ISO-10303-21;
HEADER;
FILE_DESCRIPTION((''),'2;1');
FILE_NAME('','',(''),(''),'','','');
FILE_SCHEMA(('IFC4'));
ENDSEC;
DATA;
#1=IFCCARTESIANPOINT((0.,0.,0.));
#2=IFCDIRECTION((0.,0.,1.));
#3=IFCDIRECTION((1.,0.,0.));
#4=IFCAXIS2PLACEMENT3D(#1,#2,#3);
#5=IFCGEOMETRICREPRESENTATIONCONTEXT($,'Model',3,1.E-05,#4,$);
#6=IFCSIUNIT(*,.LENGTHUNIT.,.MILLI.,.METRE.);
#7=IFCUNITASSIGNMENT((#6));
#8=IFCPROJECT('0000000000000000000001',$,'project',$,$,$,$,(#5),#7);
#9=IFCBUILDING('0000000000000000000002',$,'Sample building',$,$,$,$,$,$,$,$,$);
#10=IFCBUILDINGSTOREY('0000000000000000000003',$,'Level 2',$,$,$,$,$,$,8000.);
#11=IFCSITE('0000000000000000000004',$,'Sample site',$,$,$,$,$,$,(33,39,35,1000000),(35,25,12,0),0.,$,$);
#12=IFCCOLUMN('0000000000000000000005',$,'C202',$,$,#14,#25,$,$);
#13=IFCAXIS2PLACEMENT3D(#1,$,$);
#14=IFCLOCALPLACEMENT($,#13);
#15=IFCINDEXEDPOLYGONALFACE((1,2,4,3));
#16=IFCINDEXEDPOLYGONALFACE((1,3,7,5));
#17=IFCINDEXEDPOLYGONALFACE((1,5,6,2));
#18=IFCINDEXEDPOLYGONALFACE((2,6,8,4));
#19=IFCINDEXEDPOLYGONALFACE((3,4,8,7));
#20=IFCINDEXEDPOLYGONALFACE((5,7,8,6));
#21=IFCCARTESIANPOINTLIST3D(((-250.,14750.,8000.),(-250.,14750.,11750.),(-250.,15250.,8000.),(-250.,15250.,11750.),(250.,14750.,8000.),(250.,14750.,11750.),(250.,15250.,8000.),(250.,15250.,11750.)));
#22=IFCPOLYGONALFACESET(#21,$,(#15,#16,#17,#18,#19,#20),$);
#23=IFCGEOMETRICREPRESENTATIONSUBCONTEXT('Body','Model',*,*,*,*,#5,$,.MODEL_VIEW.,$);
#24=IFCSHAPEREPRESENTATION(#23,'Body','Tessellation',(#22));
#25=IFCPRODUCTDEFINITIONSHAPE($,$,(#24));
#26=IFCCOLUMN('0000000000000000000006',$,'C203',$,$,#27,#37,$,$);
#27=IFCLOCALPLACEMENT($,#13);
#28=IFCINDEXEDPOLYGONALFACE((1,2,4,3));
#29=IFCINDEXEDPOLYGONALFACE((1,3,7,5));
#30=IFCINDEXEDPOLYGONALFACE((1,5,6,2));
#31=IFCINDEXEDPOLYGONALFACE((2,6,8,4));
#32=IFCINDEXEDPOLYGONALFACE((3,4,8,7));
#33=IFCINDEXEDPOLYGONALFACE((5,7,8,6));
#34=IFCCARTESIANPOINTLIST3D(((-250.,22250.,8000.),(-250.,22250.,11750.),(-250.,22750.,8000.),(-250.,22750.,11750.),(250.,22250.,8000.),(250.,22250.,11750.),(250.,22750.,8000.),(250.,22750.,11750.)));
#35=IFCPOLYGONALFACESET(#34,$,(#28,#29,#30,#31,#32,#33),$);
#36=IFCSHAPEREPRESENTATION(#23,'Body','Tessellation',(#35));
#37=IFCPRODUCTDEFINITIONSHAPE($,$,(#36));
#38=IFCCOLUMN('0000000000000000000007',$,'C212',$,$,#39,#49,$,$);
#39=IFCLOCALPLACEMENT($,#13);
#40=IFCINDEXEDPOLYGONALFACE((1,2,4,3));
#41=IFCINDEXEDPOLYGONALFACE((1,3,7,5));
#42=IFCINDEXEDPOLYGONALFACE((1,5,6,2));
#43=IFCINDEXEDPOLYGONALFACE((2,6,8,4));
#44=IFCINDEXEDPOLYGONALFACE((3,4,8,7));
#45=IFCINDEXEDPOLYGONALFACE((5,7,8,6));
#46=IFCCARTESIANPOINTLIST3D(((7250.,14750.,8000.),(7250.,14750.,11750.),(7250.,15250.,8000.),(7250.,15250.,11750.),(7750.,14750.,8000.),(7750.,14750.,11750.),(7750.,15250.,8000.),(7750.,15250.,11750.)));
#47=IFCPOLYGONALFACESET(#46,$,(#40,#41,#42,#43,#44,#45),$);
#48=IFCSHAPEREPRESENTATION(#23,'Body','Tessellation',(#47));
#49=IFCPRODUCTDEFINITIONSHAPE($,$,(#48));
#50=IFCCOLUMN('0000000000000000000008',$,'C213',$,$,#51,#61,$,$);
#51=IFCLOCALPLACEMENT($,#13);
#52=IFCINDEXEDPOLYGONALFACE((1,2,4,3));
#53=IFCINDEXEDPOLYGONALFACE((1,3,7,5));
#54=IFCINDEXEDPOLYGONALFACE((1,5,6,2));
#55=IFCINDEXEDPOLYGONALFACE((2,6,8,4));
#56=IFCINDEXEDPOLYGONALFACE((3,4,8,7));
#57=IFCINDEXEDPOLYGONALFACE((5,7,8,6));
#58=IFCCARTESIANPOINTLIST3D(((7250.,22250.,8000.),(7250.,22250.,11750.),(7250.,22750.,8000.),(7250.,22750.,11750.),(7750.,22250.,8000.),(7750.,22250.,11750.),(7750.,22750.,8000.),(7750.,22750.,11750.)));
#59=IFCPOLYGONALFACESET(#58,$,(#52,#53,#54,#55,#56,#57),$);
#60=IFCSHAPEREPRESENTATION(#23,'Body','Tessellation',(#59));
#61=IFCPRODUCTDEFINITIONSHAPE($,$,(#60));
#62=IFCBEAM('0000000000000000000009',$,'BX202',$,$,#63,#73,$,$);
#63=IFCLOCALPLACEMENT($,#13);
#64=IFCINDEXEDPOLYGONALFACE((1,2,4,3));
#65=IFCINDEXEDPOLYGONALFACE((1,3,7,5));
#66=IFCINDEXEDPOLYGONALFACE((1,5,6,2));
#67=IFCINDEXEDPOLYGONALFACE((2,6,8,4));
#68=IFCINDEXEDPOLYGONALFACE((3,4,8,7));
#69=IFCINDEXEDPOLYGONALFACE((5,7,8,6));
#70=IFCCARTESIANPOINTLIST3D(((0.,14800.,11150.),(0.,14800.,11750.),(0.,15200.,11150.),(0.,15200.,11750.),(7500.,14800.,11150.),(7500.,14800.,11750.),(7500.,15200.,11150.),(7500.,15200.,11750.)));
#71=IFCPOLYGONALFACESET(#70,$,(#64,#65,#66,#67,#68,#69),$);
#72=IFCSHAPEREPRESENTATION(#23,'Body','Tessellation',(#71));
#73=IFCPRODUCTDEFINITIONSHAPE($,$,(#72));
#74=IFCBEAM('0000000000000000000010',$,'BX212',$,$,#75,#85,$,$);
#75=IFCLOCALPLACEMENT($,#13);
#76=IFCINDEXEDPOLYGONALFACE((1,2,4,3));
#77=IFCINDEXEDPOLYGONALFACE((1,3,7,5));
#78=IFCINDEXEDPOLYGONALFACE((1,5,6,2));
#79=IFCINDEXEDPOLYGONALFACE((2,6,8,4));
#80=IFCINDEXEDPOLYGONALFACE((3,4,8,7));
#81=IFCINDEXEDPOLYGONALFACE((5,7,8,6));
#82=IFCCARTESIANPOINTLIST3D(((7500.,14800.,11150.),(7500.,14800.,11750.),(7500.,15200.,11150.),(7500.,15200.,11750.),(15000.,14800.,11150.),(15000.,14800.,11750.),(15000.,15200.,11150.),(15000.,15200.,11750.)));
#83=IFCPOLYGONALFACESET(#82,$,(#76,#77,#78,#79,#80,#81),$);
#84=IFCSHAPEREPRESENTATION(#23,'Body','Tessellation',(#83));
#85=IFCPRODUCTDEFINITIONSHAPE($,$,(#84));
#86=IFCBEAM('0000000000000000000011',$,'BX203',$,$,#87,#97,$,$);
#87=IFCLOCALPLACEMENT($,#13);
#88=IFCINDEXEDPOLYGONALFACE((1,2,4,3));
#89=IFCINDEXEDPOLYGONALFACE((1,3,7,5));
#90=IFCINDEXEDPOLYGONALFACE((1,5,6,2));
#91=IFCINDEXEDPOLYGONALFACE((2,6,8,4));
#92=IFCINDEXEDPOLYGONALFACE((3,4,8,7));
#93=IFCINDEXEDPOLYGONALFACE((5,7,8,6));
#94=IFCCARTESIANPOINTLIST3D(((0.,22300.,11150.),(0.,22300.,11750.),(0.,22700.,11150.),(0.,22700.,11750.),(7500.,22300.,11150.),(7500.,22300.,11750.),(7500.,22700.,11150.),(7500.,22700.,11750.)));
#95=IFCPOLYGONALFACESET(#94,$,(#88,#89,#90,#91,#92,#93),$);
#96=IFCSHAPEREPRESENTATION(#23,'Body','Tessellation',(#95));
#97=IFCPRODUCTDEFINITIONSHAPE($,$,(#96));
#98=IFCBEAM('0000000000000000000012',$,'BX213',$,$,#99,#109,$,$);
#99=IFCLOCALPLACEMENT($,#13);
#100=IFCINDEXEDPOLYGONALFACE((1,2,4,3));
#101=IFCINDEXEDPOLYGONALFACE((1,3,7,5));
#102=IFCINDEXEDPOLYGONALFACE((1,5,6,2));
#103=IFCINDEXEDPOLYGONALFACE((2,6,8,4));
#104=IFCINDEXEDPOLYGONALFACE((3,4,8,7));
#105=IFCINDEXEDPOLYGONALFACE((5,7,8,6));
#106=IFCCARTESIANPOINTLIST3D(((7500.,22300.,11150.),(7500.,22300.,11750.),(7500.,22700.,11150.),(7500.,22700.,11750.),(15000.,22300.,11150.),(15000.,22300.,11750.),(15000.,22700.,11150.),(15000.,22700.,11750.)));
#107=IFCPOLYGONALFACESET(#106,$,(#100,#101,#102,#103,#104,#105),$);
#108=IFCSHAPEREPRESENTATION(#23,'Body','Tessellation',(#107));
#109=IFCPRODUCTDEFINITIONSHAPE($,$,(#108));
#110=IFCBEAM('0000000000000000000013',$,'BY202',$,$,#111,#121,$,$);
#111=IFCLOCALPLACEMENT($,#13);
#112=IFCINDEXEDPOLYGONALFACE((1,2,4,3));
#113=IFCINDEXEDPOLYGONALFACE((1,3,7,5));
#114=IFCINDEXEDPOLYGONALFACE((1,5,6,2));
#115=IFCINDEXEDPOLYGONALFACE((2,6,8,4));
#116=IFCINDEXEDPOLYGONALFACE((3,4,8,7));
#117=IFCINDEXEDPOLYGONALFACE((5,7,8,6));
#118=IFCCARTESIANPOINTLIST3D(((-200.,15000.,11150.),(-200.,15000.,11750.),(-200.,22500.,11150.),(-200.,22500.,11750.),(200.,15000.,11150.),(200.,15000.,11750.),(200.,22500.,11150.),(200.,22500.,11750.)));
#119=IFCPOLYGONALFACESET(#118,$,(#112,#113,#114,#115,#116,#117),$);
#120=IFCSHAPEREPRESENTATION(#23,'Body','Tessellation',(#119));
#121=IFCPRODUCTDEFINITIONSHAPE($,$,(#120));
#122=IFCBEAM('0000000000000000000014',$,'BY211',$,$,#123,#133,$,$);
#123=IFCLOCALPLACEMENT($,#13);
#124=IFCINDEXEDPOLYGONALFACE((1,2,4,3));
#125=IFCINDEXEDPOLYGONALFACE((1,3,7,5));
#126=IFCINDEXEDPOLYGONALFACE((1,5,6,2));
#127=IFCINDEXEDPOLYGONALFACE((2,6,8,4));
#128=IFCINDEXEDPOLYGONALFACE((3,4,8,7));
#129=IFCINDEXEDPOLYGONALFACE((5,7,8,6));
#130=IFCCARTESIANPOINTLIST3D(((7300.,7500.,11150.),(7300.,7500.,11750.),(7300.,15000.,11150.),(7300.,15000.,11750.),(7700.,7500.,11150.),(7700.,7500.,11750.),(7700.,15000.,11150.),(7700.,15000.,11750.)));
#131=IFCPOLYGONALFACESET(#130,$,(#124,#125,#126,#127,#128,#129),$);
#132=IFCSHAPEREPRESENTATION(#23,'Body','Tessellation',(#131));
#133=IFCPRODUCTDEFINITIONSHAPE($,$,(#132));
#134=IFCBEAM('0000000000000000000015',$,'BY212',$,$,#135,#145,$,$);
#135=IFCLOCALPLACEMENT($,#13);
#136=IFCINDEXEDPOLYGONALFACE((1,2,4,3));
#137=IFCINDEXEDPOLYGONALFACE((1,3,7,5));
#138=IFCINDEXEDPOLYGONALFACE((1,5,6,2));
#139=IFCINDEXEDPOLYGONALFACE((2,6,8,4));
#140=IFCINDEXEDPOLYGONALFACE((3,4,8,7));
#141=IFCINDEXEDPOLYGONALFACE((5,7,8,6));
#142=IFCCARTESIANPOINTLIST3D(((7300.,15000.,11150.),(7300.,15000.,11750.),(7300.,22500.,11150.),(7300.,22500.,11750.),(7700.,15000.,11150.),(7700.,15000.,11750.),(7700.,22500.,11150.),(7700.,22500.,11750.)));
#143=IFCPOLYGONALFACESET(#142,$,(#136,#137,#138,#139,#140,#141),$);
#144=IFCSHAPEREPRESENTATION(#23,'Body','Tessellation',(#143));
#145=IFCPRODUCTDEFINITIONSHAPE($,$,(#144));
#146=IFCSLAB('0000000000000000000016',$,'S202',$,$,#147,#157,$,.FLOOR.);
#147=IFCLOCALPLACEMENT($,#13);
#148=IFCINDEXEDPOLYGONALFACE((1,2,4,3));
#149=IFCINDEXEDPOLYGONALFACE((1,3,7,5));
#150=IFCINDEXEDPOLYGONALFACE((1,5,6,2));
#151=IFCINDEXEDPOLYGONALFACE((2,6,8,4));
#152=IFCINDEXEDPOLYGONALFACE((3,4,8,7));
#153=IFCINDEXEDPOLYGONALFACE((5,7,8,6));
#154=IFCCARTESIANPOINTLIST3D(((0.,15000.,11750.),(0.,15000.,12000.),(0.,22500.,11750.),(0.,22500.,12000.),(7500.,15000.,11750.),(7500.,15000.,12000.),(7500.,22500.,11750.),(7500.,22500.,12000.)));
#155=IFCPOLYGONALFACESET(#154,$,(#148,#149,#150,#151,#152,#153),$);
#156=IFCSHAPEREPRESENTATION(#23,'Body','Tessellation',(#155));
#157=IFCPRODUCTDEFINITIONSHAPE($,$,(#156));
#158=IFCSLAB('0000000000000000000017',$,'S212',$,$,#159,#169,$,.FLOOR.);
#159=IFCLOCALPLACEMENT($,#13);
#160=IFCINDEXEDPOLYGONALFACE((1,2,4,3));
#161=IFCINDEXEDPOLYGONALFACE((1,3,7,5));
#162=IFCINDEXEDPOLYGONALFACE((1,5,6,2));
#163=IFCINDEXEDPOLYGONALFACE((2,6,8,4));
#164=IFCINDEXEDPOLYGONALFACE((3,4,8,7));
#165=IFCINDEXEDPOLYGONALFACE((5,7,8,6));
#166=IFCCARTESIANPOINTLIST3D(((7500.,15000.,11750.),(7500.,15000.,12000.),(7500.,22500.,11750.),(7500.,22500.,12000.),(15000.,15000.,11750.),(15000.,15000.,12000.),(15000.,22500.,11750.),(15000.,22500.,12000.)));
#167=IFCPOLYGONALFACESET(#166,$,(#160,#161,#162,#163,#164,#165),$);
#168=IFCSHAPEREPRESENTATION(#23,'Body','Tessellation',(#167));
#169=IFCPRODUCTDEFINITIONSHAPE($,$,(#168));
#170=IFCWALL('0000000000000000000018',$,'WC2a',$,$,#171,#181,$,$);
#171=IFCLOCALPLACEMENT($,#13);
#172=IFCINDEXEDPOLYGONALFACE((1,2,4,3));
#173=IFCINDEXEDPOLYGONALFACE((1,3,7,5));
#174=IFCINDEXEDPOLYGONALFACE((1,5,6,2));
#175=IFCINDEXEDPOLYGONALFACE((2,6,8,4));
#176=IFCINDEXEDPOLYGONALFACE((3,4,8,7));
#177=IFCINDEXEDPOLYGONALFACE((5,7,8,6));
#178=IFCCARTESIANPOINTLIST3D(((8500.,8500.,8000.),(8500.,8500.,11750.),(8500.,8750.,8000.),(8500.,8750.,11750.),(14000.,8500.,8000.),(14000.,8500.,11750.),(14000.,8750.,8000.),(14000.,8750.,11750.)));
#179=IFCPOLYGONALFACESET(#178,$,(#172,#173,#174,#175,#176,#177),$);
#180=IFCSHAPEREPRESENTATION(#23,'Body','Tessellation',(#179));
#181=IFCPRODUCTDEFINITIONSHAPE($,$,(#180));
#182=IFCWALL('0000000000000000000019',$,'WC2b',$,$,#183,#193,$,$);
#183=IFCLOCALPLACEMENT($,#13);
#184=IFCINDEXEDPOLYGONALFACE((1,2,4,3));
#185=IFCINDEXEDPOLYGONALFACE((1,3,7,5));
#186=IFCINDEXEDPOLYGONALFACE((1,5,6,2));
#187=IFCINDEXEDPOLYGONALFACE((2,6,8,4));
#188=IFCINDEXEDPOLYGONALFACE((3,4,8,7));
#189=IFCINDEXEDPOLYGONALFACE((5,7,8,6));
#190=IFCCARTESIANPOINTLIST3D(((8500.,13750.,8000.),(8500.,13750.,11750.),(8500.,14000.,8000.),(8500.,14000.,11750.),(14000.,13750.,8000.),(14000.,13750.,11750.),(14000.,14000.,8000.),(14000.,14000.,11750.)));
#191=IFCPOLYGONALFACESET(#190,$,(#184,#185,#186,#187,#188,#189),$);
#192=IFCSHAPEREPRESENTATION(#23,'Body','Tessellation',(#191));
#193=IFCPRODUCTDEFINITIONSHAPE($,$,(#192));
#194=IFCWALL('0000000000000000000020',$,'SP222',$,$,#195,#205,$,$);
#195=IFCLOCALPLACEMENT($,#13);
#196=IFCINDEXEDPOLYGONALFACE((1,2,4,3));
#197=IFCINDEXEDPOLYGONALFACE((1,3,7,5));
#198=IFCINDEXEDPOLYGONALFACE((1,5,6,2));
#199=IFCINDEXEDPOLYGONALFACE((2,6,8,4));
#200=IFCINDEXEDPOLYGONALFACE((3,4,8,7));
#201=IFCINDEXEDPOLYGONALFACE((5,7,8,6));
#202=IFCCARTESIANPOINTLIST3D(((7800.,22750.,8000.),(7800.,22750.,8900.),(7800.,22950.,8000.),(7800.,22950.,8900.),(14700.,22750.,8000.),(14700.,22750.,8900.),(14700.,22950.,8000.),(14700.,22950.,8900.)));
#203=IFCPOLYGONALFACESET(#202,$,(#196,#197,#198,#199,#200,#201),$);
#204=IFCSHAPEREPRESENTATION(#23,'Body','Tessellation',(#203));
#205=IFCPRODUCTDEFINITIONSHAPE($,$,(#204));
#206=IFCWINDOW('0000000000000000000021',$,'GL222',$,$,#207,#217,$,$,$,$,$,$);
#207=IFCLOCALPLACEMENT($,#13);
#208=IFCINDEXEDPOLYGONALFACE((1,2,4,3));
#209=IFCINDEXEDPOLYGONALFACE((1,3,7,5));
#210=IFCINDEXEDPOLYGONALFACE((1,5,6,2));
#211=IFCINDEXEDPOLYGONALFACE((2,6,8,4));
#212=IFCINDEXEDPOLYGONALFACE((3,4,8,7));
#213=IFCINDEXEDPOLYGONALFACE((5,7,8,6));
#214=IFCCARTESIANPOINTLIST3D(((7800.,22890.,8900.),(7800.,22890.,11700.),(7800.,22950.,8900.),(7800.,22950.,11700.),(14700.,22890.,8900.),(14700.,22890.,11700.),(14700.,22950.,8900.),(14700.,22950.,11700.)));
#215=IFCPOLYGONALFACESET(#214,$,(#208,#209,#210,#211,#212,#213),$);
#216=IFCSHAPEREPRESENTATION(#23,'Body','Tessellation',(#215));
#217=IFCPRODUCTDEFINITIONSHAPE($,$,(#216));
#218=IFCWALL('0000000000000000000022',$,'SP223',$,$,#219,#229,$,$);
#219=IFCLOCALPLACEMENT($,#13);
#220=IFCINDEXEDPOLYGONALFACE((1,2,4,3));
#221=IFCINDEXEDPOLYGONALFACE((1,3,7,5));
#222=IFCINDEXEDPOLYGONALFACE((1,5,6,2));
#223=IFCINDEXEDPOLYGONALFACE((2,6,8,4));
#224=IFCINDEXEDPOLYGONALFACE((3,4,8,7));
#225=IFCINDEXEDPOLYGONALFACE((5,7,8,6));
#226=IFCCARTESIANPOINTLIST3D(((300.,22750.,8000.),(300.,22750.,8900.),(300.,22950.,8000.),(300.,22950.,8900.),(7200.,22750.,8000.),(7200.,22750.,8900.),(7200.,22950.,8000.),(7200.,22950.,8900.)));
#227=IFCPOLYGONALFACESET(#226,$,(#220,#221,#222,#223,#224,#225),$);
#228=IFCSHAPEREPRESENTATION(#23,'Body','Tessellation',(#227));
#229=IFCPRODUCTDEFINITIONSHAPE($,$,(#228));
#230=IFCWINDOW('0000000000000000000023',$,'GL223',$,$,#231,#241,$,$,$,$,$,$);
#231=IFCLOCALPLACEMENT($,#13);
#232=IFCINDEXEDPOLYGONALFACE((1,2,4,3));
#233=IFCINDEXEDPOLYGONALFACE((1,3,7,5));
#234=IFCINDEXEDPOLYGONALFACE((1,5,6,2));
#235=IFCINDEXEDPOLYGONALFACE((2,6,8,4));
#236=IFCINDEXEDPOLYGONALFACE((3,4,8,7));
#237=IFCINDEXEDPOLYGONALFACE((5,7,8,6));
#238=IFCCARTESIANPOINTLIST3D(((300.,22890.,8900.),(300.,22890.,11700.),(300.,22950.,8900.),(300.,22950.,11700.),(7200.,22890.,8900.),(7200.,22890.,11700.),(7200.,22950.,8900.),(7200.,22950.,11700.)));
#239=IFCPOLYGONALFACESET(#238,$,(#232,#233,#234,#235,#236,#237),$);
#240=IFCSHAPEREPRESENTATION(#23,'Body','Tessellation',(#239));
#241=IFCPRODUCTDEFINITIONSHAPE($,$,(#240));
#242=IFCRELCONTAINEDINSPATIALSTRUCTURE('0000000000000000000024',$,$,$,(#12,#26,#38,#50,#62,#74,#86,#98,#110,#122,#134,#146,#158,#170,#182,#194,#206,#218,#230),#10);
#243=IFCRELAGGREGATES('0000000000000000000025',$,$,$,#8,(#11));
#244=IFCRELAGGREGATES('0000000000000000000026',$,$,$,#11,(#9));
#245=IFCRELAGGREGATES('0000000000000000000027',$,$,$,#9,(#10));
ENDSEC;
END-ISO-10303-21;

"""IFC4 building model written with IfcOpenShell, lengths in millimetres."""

from ifc_helpers import new_model, si_unit, frame, origin_with_axes, place, context, subcontext, project, spatial, indexed_curve, outline, extrude, element, save


model = new_model("IFC4")

# Units and contexts
model_context = context("Model", 3, precision=1e-05, world=origin_with_axes())
body_context = subcontext(model_context, "Body", "Model", "MODEL_VIEW")
ifc_project = project(units=[si_unit("LENGTHUNIT", "METRE", prefix="MILLI")], contexts=[model_context])

# Site, building, storey
site = spatial("IfcSite", under=ifc_project, Name="Sample site", RefLatitude=(33, 39, 35, 1000000), RefLongitude=(35, 25, 12, 0), RefElevation=0.0)
building = spatial("IfcBuilding", under=site, Name="Sample building")
storey = spatial("IfcBuildingStorey", under=building, Name="Level 2", Elevation=8000.0)

# Columns
for number, where, z_axis, x_axis, name in (
    (1, (-250.0, 14750.0, 8000.0), (0.0, 0.0, 1.0), (1.0, 0.0, 0.0), "C202"),
    (2, (-250.0, 22250.0, 8000.0), (0.0, 0.0, 1.0), (1.0, 0.0, 0.0), "C203"),
    (3, (7250.0, 14750.0, 8000.0), (0.0, 0.0, 1.0), (1.0, 0.0, 0.0), "C212"),
    (4, (7250.0, 22250.0, 8000.0), (0.0, 0.0, 1.0), (1.0, 0.0, 0.0), "C213"),
):
    element("IfcColumn", number, at=place(None, frame(where, z_axis=z_axis, x_axis=x_axis)), inside=storey, Name=name, context=body_context, shape_type="SweptSolid", body=[
        extrude(outline(indexed_curve([(0.0, 0.0), (0.0, 500.0), (500.0, 500.0), (500.0, 0.0), (0.0, 0.0)], self_intersect=False)), origin_with_axes(), (0.0, 0.0, 1.0), 3750.0),
    ])

# Beams
for number, where, z_axis, x_axis, name in (
    (5, (0.0, 14800.0, 11150.0), (0.0, 0.0, 1.0), (1.0, 0.0, 0.0), "BX202"),
    (6, (7500.0, 14800.0, 11150.0), (0.0, 0.0, 1.0), (1.0, 0.0, 0.0), "BX212"),
    (7, (0.0, 22300.0, 11150.0), (0.0, 0.0, 1.0), (1.0, 0.0, 0.0), "BX203"),
    (8, (7500.0, 22300.0, 11150.0), (0.0, 0.0, 1.0), (1.0, 0.0, 0.0), "BX213"),
    (9, (200.0, 15000.0, 11150.0), (0.0, 0.0, 1.0), (0.0, 1.0, 0.0), "BY202"),
    (10, (7700.0, 7500.0, 11150.0), (0.0, 0.0, 1.0), (0.0, 1.0, 0.0), "BY211"),
    (11, (7700.0, 15000.0, 11150.0), (0.0, 0.0, 1.0), (0.0, 1.0, 0.0), "BY212"),
):
    element("IfcBeam", number, at=place(None, frame(where, z_axis=z_axis, x_axis=x_axis)), inside=storey, Name=name, context=body_context, shape_type="SweptSolid", body=[
        extrude(outline(indexed_curve([(0.0, 0.0), (0.0, 400.0), (7500.0, 400.0), (7500.0, 0.0), (0.0, 0.0)], self_intersect=False)), origin_with_axes(), (0.0, 0.0, 1.0), 600.0),
    ])

# Slabs
for number, where, z_axis, x_axis, name in (
    (12, (0.0, 15000.0, 11750.0), (0.0, 0.0, 1.0), (1.0, 0.0, 0.0), "S202"),
    (13, (7500.0, 15000.0, 11750.0), (0.0, 0.0, 1.0), (1.0, 0.0, 0.0), "S212"),
):
    element("IfcSlab", number, at=place(None, frame(where, z_axis=z_axis, x_axis=x_axis)), inside=storey, Name=name, PredefinedType="FLOOR", context=body_context, shape_type="SweptSolid", body=[
        extrude(outline(indexed_curve([(0.0, 0.0), (0.0, 7500.0), (7500.0, 7500.0), (7500.0, 0.0), (0.0, 0.0)], self_intersect=False)), origin_with_axes(), (0.0, 0.0, 1.0), 250.0),
    ])

# Walls
for number, where, z_axis, x_axis, name in (
    (14, (8500.0, 8500.0, 8000.0), (0.0, 0.0, 1.0), (1.0, 0.0, 0.0), "WC2a"),
    (15, (8500.0, 13750.0, 8000.0), (0.0, 0.0, 1.0), (1.0, 0.0, 0.0), "WC2b"),
):
    element("IfcWall", number, at=place(None, frame(where, z_axis=z_axis, x_axis=x_axis)), inside=storey, Name=name, context=body_context, shape_type="SweptSolid", body=[
        extrude(outline(indexed_curve([(0.0, 0.0), (0.0, 250.0), (5500.0, 250.0), (5500.0, 0.0), (0.0, 0.0)], self_intersect=False)), origin_with_axes(), (0.0, 0.0, 1.0), 3750.0),
    ])
wall_1_placement = place(None, frame((14700.0, 22950.0, 8000.0), z_axis=(0.0, 0.0, 1.0), x_axis=(-1.0, 0.0, 0.0)))
element("IfcWall", 16, at=wall_1_placement, inside=storey, Name="SP222", context=body_context, shape_type="SweptSolid", body=[
    extrude(outline(indexed_curve([(0.0, 0.0), (0.0, 200.0), (6900.0, 200.0), (6900.0, 0.0), (0.0, 0.0)], self_intersect=False)), origin_with_axes(), (0.0, 0.0, 1.0), 900.0),
])

# Window
window_1_placement = place(None, frame((14700.0, 22950.0, 8900.0), z_axis=(0.0, 0.0, 1.0), x_axis=(-1.0, 0.0, 0.0)))
element("IfcWindow", 17, at=window_1_placement, inside=storey, Name="GL222", context=body_context, shape_type="SweptSolid", body=[
    extrude(outline(indexed_curve([(0.0, 0.0), (0.0, 60.0), (6900.0, 60.0), (6900.0, 0.0), (0.0, 0.0)], self_intersect=False)), origin_with_axes(), (0.0, 0.0, 1.0), 2800.0),
])

# Wall
wall_2_placement = place(None, frame((7200.0, 22950.0, 8000.0), z_axis=(0.0, 0.0, 1.0), x_axis=(-1.0, 0.0, 0.0)))
element("IfcWall", 18, at=wall_2_placement, inside=storey, Name="SP223", context=body_context, shape_type="SweptSolid", body=[
    extrude(outline(indexed_curve([(0.0, 0.0), (0.0, 200.0), (6900.0, 200.0), (6900.0, 0.0), (0.0, 0.0)], self_intersect=False)), origin_with_axes(), (0.0, 0.0, 1.0), 900.0),
])

# Window
window_2_placement = place(None, frame((7200.0, 22950.0, 8900.0), z_axis=(0.0, 0.0, 1.0), x_axis=(-1.0, 0.0, 0.0)))
element("IfcWindow", 19, at=window_2_placement, inside=storey, Name="GL223", context=body_context, shape_type="SweptSolid", body=[
    extrude(outline(indexed_curve([(0.0, 0.0), (0.0, 60.0), (6900.0, 60.0), (6900.0, 0.0), (0.0, 0.0)], self_intersect=False)), origin_with_axes(), (0.0, 0.0, 1.0), 2800.0),
])

save(model, "model.ifc")
